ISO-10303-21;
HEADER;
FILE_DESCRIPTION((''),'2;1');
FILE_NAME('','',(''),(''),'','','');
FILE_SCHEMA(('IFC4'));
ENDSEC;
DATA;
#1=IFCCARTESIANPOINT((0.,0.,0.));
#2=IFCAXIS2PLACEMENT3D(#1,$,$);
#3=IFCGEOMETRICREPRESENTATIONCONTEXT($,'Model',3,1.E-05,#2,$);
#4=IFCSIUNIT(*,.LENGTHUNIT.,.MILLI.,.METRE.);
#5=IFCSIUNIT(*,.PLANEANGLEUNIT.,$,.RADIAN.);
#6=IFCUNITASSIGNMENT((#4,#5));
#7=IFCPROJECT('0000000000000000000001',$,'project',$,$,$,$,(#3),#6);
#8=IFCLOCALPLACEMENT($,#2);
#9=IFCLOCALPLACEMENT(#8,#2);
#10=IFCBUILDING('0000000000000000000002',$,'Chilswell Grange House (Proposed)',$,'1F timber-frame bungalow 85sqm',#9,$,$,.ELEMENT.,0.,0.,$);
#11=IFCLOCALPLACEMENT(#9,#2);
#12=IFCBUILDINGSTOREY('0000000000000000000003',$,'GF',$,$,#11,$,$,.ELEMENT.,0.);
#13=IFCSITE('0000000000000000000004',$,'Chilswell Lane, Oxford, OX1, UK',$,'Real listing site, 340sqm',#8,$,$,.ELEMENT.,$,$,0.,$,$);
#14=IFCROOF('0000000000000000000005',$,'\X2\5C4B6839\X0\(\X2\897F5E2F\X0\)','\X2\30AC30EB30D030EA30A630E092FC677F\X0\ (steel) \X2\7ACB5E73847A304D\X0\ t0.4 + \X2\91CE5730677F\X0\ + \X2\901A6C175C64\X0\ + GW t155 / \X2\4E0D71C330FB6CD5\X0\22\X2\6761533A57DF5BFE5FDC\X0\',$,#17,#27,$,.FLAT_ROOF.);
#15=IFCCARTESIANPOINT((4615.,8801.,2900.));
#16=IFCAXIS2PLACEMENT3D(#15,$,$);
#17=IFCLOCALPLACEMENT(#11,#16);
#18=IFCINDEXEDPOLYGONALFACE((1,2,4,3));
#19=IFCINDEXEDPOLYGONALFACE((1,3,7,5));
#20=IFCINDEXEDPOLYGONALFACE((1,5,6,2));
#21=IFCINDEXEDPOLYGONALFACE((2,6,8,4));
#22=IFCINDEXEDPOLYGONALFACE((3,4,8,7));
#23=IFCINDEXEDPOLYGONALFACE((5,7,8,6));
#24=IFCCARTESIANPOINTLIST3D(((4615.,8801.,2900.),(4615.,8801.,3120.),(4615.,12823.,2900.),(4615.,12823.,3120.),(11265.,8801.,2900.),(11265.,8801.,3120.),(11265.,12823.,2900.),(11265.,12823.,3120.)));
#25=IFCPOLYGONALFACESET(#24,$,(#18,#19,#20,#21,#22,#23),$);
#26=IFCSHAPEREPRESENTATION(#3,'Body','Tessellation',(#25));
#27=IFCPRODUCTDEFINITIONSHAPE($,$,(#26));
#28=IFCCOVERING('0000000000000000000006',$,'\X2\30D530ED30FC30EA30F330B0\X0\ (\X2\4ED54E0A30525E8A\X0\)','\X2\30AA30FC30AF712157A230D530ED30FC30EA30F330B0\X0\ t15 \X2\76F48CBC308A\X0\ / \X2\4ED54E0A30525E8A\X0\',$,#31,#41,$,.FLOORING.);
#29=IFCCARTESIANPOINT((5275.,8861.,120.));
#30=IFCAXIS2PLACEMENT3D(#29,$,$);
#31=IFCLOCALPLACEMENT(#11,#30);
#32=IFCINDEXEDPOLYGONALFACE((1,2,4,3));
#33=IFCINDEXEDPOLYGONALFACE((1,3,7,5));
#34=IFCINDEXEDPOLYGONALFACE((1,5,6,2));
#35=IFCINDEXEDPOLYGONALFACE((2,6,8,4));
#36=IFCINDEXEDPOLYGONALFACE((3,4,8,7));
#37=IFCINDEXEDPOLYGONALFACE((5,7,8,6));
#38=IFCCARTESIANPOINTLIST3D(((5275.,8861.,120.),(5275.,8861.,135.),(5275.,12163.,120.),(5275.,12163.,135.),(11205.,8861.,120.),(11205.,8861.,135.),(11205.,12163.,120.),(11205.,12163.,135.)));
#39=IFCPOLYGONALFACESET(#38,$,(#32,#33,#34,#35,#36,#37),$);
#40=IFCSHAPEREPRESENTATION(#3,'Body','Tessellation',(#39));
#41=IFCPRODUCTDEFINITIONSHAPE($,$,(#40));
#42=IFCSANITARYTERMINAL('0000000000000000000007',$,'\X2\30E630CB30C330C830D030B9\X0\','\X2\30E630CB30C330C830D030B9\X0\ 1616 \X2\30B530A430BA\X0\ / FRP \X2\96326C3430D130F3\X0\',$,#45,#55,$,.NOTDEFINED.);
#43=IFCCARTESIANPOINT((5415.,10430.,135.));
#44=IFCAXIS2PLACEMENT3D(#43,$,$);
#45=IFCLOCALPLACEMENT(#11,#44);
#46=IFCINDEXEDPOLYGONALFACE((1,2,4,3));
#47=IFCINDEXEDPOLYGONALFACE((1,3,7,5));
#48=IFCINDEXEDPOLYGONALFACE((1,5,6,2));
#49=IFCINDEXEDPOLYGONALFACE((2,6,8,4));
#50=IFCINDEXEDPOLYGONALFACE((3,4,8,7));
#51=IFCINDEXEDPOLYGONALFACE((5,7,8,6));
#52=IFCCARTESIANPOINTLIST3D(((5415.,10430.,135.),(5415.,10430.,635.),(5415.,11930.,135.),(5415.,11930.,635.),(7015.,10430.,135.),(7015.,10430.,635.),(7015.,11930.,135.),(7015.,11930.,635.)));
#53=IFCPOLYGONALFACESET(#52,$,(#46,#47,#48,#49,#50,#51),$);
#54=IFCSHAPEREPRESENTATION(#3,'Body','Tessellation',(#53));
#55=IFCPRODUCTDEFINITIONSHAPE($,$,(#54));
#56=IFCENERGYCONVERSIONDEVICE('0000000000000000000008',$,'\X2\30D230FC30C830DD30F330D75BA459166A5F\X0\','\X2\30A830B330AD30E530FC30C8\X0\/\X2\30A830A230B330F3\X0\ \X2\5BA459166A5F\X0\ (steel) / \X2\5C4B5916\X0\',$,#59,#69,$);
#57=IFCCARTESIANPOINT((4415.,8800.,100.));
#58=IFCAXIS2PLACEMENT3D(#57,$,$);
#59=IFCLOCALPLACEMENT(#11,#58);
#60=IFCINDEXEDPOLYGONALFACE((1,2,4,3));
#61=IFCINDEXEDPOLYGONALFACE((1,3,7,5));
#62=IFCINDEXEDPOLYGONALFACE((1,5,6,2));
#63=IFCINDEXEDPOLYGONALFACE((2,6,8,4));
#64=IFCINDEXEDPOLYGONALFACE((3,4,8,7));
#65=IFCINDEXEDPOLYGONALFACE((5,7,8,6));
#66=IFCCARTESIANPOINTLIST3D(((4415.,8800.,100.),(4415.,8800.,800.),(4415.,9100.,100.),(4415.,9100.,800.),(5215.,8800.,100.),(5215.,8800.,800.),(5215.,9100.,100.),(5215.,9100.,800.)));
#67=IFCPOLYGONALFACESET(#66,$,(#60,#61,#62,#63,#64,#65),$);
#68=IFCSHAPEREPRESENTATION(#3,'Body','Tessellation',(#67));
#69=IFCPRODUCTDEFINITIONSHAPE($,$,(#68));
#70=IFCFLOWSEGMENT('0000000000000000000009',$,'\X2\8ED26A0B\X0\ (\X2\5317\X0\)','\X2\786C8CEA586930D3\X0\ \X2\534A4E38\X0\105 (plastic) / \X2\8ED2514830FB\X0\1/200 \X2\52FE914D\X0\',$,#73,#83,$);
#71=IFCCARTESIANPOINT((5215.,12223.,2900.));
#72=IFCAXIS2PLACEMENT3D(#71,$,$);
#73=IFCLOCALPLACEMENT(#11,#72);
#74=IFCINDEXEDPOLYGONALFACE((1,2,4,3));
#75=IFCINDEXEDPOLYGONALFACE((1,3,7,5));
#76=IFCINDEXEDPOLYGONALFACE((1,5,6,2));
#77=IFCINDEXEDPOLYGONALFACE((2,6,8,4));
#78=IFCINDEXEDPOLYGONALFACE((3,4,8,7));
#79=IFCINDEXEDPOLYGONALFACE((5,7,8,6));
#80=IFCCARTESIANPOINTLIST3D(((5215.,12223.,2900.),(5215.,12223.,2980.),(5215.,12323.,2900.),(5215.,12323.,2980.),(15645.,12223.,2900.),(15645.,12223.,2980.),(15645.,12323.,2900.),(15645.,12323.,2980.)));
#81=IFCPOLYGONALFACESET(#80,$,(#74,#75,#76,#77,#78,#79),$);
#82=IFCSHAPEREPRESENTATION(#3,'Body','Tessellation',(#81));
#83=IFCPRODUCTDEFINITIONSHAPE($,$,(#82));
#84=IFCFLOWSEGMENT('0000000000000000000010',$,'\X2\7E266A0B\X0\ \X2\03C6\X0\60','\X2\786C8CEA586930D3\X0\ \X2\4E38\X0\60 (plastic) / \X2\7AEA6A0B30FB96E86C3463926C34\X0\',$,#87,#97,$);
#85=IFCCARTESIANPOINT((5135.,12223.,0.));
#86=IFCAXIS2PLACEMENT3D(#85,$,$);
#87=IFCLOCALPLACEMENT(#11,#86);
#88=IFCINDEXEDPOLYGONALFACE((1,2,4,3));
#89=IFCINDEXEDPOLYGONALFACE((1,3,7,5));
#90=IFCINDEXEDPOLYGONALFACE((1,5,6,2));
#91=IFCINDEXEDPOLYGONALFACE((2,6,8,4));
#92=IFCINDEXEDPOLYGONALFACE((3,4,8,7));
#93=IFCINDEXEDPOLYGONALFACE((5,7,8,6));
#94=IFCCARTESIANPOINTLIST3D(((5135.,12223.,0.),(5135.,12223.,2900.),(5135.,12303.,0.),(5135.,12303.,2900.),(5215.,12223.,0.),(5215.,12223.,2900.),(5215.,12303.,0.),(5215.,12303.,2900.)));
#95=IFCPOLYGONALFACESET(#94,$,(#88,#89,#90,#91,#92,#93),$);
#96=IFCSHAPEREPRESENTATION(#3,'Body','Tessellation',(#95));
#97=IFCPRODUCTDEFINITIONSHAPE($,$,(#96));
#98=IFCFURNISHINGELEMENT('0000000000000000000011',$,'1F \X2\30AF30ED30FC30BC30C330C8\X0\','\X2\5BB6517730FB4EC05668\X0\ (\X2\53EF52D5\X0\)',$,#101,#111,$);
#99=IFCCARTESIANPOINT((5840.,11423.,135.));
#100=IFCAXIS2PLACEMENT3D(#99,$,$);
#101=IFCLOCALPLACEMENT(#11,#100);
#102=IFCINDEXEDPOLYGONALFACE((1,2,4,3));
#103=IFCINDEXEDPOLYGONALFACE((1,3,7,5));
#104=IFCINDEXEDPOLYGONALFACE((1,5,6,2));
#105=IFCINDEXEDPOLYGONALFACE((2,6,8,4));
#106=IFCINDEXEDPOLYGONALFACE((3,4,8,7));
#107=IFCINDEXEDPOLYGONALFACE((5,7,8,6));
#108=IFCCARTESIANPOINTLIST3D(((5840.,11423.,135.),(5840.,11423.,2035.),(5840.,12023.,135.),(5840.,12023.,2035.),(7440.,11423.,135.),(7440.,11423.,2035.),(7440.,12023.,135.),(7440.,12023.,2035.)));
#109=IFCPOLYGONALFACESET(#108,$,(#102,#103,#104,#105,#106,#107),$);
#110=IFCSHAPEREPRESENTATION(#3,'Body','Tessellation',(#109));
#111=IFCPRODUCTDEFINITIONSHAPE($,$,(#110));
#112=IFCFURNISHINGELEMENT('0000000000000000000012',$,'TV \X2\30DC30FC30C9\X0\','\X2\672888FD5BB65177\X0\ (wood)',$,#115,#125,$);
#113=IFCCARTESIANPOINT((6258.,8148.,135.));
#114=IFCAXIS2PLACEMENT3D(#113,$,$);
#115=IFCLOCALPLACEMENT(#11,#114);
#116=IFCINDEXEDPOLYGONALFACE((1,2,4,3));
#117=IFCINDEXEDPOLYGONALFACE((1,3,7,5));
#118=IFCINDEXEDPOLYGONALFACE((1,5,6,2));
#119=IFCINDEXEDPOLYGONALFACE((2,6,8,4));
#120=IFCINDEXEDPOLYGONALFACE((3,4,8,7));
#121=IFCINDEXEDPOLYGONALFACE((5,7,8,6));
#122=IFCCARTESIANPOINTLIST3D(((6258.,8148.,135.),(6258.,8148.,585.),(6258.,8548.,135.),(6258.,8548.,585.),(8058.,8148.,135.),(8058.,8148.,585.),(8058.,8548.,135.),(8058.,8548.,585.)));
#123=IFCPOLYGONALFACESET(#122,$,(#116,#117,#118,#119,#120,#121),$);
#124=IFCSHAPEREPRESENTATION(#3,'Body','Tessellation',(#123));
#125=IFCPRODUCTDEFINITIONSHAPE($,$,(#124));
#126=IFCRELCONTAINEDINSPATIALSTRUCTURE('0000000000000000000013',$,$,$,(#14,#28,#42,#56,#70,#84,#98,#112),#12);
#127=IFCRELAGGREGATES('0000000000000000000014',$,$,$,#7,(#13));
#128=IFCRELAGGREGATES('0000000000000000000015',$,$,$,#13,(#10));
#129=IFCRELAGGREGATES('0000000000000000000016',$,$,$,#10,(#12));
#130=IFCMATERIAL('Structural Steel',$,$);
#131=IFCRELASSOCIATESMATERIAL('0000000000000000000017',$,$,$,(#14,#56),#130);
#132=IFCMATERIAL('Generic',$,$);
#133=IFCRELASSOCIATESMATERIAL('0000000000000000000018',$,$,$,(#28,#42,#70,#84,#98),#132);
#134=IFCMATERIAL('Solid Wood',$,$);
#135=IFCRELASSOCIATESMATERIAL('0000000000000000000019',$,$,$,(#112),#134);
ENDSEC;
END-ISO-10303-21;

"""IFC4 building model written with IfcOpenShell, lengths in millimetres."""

from ifc_helpers import new_model, si_unit, frame, frame_2d, origin, place, context, project, spatial, rectangle, extrude, material, element, save


model = new_model("IFC4")

# Units and contexts
model_context = context("Model", 3, precision=1e-05, world=origin())
ifc_project = project(units=[si_unit("LENGTHUNIT", "METRE", prefix="MILLI"), si_unit("PLANEANGLEUNIT", "RADIAN")], contexts=[model_context])

# Site, building, storey
site_placement = place(None, origin())
site = spatial("IfcSite", under=ifc_project, at=site_placement, Name="Chilswell Lane, Oxford, OX1, UK", ObjectType="Real listing site, 340sqm", CompositionType="ELEMENT", RefElevation=0.0)
building_placement = place(site_placement, origin())
building = spatial("IfcBuilding", under=site, at=building_placement, Name="Chilswell Grange House (Proposed)", ObjectType="1F timber-frame bungalow 85sqm", CompositionType="ELEMENT", ElevationOfRefHeight=0.0, ElevationOfTerrain=0.0)
storey_placement = place(building_placement, origin())
storey = spatial("IfcBuildingStorey", under=building, at=storey_placement, Name="GF", CompositionType="ELEMENT", Elevation=0.0)

# Shared definitions
ifc_material_1 = material(Name="Solid Wood")

# Roof
ifc_material_2 = material(Name="Structural Steel")
roof_placement = place(storey_placement, frame((4615.0, 8801.0, 2900.0)))
element("IfcRoof", 1, at=roof_placement, inside=storey, material=ifc_material_2, Name="屋根(西帯)", Description="ガルバリウム鋼板 (steel) 立平葺き t0.4 + 野地板 + 通気層 + GW t155 / 不燃・法22条区域対応", PredefinedType="FLAT_ROOF", context=model_context, shape_type="SweptSolid", body=[
    extrude(rectangle(XDim=6650.0, YDim=4022.0, at=frame_2d((3325.0, 2011.0))), frame((4615.0, 8801.0, 2900.0)), (0.0, 0.0, 1.0), 220.0),
])

# Covering
ifc_material_3 = material(Name="Generic")
covering_placement = place(storey_placement, frame((5275.0, 8861.0, 120.0)))
element("IfcCovering", 2, at=covering_placement, inside=storey, material=ifc_material_3, Name="フローリング (仕上げ床)", Description="オーク無垢フローリング t15 直貼り / 仕上げ床", PredefinedType="FLOORING", context=model_context, shape_type="SweptSolid", body=[
    extrude(rectangle(XDim=5930.0, YDim=3302.0, at=frame_2d((2965.0, 1651.0))), frame((5275.0, 8861.0, 120.0)), (0.0, 0.0, 1.0), 15.0),
])

# Sanitary terminal
sanitary_terminal_placement = place(storey_placement, frame((5415.0, 10430.0, 135.0)))
element("IfcSanitaryTerminal", 3, at=sanitary_terminal_placement, inside=storey, material=ifc_material_3, Name="ユニットバス", Description="ユニットバス 1616 サイズ / FRP 防水パン", PredefinedType="NOTDEFINED", context=model_context, shape_type="SweptSolid", body=[
    extrude(rectangle(XDim=1600.0, YDim=1500.0, at=frame_2d((800.0, 750.0))), frame((5415.0, 10430.0, 135.0)), (0.0, 0.0, 1.0), 500.0),
])

# Energy conversion device
energy_conversion_device_placement = place(storey_placement, frame((4415.0, 8800.0, 100.0)))
element("IfcEnergyConversionDevice", 4, at=energy_conversion_device_placement, inside=storey, material=ifc_material_2, Name="ヒートポンプ室外機", Description="エコキュート/エアコン 室外機 (steel) / 屋外", context=model_context, shape_type="SweptSolid", body=[
    extrude(rectangle(XDim=800.0, YDim=300.0, at=frame_2d((400.0, 150.0))), frame((4415.0, 8800.0, 100.0)), (0.0, 0.0, 1.0), 700.0),
])

# Flow segments
flow_segment_1_placement = place(storey_placement, frame((5215.0, 12223.0, 2900.0)))
element("IfcFlowSegment", 5, at=flow_segment_1_placement, inside=storey, material=ifc_material_3, Name="軒樋 (北)", Description="硬質塩ビ 半丸105 (plastic) / 軒先・1/200 勾配", context=model_context, shape_type="SweptSolid", body=[
    extrude(rectangle(XDim=10430.0, YDim=100.0, at=frame_2d((5215.0, 50.0))), frame((5215.0, 12223.0, 2900.0)), (0.0, 0.0, 1.0), 80.0),
])
flow_segment_2_placement = place(storey_placement, frame((5135.0, 12223.0, 0.0)))
element("IfcFlowSegment", 6, at=flow_segment_2_placement, inside=storey, material=ifc_material_3, Name="縦樋 φ60", Description="硬質塩ビ 丸60 (plastic) / 竪樋・雨水排水", context=model_context, shape_type="SweptSolid", body=[
    extrude(rectangle(XDim=80.0, YDim=80.0, at=frame_2d((40.0, 40.0))), frame((5135.0, 12223.0, 0.0)), (0.0, 0.0, 1.0), 2900.0),
])

# Furnishing elements
furnishing_1_placement = place(storey_placement, frame((5840.0, 11423.0, 135.0)))
element("IfcFurnishingElement", 7, at=furnishing_1_placement, inside=storey, material=ifc_material_3, Name="1F クローゼット", Description="家具・什器 (可動)", context=model_context, shape_type="SweptSolid", body=[
    extrude(rectangle(XDim=1600.0, YDim=600.0, at=frame_2d((800.0, 300.0))), frame((5840.0, 11423.0, 135.0)), (0.0, 0.0, 1.0), 1900.0),
])
furnishing_2_placement = place(storey_placement, frame((6258.0, 8148.0, 135.0)))
element("IfcFurnishingElement", 8, at=furnishing_2_placement, inside=storey, material=ifc_material_1, Name="TV ボード", Description="木製家具 (wood)", context=model_context, shape_type="SweptSolid", body=[
    extrude(rectangle(XDim=1800.0, YDim=400.0, at=frame_2d((900.0, 200.0))), frame((6258.0, 8148.0, 135.0)), (0.0, 0.0, 1.0), 450.0),
])

save(model, "model.ifc")
